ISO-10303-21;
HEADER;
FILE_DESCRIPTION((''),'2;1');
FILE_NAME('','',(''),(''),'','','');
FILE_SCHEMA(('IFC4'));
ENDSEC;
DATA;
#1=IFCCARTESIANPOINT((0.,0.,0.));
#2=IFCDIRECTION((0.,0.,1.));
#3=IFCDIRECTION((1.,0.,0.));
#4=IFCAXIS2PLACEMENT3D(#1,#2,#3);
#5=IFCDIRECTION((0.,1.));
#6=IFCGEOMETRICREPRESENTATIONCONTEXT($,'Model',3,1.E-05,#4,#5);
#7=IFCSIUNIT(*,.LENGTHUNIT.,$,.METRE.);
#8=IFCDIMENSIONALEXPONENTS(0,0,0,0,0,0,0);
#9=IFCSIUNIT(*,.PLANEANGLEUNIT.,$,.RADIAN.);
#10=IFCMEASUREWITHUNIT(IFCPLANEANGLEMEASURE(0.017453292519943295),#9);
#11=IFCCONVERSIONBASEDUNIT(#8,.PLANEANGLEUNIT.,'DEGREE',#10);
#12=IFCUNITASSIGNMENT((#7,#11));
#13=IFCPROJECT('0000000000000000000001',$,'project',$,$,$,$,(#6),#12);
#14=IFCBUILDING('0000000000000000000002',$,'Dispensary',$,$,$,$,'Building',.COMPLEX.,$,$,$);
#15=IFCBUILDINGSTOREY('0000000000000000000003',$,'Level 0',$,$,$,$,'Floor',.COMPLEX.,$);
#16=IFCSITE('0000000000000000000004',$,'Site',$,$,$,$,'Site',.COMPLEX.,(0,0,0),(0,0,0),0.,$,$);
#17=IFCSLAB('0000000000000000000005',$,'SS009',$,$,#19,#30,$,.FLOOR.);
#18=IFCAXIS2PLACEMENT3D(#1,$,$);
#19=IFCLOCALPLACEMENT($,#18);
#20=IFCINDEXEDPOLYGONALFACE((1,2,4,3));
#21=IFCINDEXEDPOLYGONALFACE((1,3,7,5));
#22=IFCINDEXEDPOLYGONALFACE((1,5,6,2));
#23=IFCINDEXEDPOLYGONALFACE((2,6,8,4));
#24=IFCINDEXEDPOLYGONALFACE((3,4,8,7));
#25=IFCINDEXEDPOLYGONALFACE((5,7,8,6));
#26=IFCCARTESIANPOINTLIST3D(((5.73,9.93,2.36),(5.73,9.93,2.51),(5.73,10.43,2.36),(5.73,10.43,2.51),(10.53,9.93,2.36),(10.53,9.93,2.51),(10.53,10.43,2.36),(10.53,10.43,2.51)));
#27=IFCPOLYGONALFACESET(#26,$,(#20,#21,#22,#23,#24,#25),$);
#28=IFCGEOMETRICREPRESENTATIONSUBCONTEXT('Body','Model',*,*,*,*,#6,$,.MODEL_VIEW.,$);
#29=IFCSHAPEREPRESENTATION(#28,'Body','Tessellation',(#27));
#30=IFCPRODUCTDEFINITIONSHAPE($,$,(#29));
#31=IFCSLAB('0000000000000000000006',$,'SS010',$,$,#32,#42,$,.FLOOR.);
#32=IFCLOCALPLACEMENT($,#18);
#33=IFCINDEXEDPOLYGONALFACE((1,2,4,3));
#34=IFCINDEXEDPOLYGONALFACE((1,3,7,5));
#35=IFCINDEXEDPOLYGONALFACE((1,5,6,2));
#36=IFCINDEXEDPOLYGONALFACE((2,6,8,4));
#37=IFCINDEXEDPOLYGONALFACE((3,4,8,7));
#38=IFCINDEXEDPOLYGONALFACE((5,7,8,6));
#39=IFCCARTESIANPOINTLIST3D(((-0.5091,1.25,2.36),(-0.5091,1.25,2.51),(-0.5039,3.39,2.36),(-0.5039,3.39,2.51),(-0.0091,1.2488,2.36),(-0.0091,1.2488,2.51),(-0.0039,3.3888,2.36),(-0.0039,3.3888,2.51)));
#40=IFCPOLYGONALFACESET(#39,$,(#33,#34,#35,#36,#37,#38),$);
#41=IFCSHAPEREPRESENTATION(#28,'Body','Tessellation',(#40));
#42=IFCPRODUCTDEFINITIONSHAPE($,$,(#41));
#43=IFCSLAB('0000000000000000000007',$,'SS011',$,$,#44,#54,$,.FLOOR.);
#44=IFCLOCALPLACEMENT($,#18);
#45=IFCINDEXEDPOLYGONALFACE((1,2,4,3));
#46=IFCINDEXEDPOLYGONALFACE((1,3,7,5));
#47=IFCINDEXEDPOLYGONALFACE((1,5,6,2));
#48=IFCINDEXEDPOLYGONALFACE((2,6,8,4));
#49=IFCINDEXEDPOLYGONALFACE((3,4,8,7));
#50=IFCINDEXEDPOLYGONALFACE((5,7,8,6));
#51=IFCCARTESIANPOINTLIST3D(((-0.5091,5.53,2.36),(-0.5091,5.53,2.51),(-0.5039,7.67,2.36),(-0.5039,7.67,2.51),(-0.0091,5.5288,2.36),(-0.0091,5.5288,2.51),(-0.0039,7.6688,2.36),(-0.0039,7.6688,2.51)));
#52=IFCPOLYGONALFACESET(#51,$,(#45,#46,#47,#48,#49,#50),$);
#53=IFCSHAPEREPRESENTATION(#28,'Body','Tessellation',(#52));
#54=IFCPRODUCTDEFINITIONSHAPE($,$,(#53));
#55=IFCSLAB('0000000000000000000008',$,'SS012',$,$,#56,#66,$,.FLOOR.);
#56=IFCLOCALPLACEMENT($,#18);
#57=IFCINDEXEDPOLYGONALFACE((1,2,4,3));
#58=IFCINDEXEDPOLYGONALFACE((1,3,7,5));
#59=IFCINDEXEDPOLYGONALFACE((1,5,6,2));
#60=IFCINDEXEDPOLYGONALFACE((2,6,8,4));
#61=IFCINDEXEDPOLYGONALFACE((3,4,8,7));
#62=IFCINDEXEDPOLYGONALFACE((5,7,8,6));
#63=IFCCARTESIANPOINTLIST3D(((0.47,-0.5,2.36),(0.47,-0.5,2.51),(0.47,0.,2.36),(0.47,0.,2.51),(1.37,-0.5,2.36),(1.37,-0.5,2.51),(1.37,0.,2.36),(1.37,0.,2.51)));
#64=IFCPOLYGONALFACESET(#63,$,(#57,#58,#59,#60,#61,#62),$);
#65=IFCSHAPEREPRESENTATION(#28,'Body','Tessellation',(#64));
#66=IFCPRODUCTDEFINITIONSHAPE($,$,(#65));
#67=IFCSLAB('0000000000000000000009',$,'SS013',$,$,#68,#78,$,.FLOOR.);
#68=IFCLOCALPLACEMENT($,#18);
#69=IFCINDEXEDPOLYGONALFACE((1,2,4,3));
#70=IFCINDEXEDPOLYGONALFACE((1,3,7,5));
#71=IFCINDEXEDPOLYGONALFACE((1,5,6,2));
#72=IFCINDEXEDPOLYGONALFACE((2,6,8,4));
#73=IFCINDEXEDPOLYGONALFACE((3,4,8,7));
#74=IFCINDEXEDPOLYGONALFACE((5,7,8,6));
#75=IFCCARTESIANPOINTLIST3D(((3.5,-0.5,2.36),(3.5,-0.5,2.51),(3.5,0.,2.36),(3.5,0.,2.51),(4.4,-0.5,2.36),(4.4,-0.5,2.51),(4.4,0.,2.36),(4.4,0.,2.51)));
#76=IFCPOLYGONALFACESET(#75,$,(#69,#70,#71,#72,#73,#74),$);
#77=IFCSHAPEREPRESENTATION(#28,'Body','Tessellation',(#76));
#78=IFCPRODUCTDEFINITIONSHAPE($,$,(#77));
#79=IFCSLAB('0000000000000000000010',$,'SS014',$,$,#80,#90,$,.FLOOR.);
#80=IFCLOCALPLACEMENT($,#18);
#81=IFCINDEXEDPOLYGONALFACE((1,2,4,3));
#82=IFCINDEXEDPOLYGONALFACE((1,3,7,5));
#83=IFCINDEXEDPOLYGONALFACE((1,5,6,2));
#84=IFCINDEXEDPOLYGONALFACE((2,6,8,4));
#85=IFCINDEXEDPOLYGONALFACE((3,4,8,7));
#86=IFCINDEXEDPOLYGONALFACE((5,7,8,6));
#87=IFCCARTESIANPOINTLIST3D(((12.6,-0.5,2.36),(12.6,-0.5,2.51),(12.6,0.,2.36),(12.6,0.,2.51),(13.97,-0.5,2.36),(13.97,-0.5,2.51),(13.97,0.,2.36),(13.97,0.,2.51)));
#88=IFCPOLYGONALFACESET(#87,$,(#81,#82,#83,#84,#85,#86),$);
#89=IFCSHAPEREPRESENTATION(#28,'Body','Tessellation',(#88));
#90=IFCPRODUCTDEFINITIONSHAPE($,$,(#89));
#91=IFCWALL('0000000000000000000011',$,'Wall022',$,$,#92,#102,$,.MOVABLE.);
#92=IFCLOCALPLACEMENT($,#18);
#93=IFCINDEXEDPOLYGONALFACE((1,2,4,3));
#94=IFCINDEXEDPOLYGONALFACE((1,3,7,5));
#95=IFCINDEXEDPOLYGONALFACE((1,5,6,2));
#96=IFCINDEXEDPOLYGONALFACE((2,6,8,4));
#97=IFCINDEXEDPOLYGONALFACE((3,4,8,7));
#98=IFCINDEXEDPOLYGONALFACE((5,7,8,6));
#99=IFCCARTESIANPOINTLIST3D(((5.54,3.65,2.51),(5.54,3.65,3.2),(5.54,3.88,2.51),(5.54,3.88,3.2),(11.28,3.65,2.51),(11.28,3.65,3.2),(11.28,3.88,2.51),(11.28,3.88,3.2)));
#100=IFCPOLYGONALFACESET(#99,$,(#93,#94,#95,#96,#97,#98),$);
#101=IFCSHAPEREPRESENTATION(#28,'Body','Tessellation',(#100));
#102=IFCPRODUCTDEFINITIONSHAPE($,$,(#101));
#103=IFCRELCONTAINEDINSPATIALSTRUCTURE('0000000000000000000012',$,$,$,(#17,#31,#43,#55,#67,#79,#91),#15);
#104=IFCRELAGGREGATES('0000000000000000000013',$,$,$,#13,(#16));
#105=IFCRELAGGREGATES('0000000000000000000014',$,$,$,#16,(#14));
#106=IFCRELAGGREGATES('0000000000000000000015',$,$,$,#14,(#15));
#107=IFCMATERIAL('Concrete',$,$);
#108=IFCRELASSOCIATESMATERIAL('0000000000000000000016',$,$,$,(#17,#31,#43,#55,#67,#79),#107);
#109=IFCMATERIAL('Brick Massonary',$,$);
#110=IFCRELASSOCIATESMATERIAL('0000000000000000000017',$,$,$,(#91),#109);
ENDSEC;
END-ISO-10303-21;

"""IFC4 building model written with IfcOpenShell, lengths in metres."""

from ifc_helpers import new_model, entity, si_unit, converted_unit, direction, frame, frame_2d, origin_with_axes, origin_2d_with_axis, place, context, subcontext, project, spatial, rectangle, extrude, material, element, save


model = new_model("IFC4")

# Units and contexts
model_context = context("Model", 3, precision=1e-05, world=origin_with_axes(), true_north=direction((0.0, 1.0)))
body_context = subcontext(model_context, "Body", "Model", "MODEL_VIEW")
ifc_project = project(units=[si_unit("LENGTHUNIT", "METRE"), converted_unit("PLANEANGLEUNIT", "DEGREE", entity("IfcPlaneAngleMeasure", 0.017453292519943295), si_unit("PLANEANGLEUNIT", "RADIAN"), dimensions=[0, 0, 0, 0, 0, 0, 0])], contexts=[model_context])

# Site, building, storey
site = spatial("IfcSite", under=ifc_project, Name="Site", LongName="Site", CompositionType="COMPLEX", RefLatitude=(0, 0, 0), RefLongitude=(0, 0, 0), RefElevation=0.0)
building = spatial("IfcBuilding", under=site, Name="Dispensary", LongName="Building", CompositionType="COMPLEX")
storey = spatial("IfcBuildingStorey", under=building, Name="Level 0", LongName="Floor", CompositionType="COMPLEX")

# Shared definitions
ifc_material_1 = material(Name="Concrete")
placement = place(None, origin_with_axes())

# Slabs
element("IfcSlab", 1, at=placement, inside=storey, material=ifc_material_1, Name="SS009", PredefinedType="FLOOR", context=body_context, shape_type="SweptSolid", body=[
    extrude(rectangle(XDim=4.8, YDim=0.15, at=frame_2d((0.0, 0.0), x_axis=(-1.0, 0.0))), frame((8.13, 10.43, 2.435), z_axis=(0.0, -1.0, 0.0), x_axis=(1.0, 0.0, 0.0)), (0.0, 0.0, 1.0), 0.5),
])
element("IfcSlab", 2, at=placement, inside=storey, material=ifc_material_1, Name="SS010", PredefinedType="FLOOR", context=body_context, shape_type="SweptSolid", body=[
    extrude(rectangle(XDim=2.14, YDim=0.15, at=frame_2d((0.0, 0.0), x_axis=(-0.002426, -0.999997))), frame((-0.5065, 2.32, 2.435), z_axis=(0.999997, -0.002426, 0.0), x_axis=(0.000006, 0.002426, -0.999997)), (0.0, 0.0, 1.0), 0.5),
])
element("IfcSlab", 3, at=placement, inside=storey, material=ifc_material_1, Name="SS011", PredefinedType="FLOOR", context=body_context, shape_type="SweptSolid", body=[
    extrude(rectangle(XDim=2.14, YDim=0.15, at=frame_2d((0.0, 0.0), x_axis=(-0.002426, -0.999997))), frame((-0.5065, 6.6, 2.435), z_axis=(0.999997, -0.002426, 0.0), x_axis=(0.000006, 0.002426, -0.999997)), (0.0, 0.0, 1.0), 0.5),
])
element("IfcSlab", 4, at=placement, inside=storey, material=ifc_material_1, Name="SS012", PredefinedType="FLOOR", context=body_context, shape_type="SweptSolid", body=[
    extrude(rectangle(XDim=0.9, YDim=0.15, at=origin_2d_with_axis()), frame((0.92, -0.5, 2.435), z_axis=(0.0, 1.0, 0.0), x_axis=(1.0, 0.0, 0.0)), (0.0, 0.0, 1.0), 0.5),
])
element("IfcSlab", 5, at=placement, inside=storey, material=ifc_material_1, Name="SS013", PredefinedType="FLOOR", context=body_context, shape_type="SweptSolid", body=[
    extrude(rectangle(XDim=0.9, YDim=0.15, at=origin_2d_with_axis()), frame((3.95, -0.5, 2.435), z_axis=(0.0, 1.0, 0.0), x_axis=(1.0, 0.0, 0.0)), (0.0, 0.0, 1.0), 0.5),
])
element("IfcSlab", 6, at=placement, inside=storey, material=ifc_material_1, Name="SS014", PredefinedType="FLOOR", context=body_context, shape_type="SweptSolid", body=[
    extrude(rectangle(XDim=1.37, YDim=0.15, at=origin_2d_with_axis()), frame((13.285, -0.5, 2.435), z_axis=(0.0, 1.0, 0.0), x_axis=(1.0, 0.0, 0.0)), (0.0, 0.0, 1.0), 0.5),
])

# Wall
ifc_material_2 = material(Name="Brick Massonary")
element("IfcWall", 7, at=placement, inside=storey, material=ifc_material_2, Name="Wall022", PredefinedType="MOVABLE", context=body_context, shape_type="SweptSolid", body=[
    extrude(rectangle(XDim=5.74, YDim=0.23, at=frame_2d((0.0, 0.0), x_axis=(1.0, 0.0))), frame((8.41, 3.765, 2.51), z_axis=(0.0, 0.0, 1.0), x_axis=(1.0, 0.0, 0.0)), (0.0, 0.0, 1.0), 0.69),
])

save(model, "model.ifc")
